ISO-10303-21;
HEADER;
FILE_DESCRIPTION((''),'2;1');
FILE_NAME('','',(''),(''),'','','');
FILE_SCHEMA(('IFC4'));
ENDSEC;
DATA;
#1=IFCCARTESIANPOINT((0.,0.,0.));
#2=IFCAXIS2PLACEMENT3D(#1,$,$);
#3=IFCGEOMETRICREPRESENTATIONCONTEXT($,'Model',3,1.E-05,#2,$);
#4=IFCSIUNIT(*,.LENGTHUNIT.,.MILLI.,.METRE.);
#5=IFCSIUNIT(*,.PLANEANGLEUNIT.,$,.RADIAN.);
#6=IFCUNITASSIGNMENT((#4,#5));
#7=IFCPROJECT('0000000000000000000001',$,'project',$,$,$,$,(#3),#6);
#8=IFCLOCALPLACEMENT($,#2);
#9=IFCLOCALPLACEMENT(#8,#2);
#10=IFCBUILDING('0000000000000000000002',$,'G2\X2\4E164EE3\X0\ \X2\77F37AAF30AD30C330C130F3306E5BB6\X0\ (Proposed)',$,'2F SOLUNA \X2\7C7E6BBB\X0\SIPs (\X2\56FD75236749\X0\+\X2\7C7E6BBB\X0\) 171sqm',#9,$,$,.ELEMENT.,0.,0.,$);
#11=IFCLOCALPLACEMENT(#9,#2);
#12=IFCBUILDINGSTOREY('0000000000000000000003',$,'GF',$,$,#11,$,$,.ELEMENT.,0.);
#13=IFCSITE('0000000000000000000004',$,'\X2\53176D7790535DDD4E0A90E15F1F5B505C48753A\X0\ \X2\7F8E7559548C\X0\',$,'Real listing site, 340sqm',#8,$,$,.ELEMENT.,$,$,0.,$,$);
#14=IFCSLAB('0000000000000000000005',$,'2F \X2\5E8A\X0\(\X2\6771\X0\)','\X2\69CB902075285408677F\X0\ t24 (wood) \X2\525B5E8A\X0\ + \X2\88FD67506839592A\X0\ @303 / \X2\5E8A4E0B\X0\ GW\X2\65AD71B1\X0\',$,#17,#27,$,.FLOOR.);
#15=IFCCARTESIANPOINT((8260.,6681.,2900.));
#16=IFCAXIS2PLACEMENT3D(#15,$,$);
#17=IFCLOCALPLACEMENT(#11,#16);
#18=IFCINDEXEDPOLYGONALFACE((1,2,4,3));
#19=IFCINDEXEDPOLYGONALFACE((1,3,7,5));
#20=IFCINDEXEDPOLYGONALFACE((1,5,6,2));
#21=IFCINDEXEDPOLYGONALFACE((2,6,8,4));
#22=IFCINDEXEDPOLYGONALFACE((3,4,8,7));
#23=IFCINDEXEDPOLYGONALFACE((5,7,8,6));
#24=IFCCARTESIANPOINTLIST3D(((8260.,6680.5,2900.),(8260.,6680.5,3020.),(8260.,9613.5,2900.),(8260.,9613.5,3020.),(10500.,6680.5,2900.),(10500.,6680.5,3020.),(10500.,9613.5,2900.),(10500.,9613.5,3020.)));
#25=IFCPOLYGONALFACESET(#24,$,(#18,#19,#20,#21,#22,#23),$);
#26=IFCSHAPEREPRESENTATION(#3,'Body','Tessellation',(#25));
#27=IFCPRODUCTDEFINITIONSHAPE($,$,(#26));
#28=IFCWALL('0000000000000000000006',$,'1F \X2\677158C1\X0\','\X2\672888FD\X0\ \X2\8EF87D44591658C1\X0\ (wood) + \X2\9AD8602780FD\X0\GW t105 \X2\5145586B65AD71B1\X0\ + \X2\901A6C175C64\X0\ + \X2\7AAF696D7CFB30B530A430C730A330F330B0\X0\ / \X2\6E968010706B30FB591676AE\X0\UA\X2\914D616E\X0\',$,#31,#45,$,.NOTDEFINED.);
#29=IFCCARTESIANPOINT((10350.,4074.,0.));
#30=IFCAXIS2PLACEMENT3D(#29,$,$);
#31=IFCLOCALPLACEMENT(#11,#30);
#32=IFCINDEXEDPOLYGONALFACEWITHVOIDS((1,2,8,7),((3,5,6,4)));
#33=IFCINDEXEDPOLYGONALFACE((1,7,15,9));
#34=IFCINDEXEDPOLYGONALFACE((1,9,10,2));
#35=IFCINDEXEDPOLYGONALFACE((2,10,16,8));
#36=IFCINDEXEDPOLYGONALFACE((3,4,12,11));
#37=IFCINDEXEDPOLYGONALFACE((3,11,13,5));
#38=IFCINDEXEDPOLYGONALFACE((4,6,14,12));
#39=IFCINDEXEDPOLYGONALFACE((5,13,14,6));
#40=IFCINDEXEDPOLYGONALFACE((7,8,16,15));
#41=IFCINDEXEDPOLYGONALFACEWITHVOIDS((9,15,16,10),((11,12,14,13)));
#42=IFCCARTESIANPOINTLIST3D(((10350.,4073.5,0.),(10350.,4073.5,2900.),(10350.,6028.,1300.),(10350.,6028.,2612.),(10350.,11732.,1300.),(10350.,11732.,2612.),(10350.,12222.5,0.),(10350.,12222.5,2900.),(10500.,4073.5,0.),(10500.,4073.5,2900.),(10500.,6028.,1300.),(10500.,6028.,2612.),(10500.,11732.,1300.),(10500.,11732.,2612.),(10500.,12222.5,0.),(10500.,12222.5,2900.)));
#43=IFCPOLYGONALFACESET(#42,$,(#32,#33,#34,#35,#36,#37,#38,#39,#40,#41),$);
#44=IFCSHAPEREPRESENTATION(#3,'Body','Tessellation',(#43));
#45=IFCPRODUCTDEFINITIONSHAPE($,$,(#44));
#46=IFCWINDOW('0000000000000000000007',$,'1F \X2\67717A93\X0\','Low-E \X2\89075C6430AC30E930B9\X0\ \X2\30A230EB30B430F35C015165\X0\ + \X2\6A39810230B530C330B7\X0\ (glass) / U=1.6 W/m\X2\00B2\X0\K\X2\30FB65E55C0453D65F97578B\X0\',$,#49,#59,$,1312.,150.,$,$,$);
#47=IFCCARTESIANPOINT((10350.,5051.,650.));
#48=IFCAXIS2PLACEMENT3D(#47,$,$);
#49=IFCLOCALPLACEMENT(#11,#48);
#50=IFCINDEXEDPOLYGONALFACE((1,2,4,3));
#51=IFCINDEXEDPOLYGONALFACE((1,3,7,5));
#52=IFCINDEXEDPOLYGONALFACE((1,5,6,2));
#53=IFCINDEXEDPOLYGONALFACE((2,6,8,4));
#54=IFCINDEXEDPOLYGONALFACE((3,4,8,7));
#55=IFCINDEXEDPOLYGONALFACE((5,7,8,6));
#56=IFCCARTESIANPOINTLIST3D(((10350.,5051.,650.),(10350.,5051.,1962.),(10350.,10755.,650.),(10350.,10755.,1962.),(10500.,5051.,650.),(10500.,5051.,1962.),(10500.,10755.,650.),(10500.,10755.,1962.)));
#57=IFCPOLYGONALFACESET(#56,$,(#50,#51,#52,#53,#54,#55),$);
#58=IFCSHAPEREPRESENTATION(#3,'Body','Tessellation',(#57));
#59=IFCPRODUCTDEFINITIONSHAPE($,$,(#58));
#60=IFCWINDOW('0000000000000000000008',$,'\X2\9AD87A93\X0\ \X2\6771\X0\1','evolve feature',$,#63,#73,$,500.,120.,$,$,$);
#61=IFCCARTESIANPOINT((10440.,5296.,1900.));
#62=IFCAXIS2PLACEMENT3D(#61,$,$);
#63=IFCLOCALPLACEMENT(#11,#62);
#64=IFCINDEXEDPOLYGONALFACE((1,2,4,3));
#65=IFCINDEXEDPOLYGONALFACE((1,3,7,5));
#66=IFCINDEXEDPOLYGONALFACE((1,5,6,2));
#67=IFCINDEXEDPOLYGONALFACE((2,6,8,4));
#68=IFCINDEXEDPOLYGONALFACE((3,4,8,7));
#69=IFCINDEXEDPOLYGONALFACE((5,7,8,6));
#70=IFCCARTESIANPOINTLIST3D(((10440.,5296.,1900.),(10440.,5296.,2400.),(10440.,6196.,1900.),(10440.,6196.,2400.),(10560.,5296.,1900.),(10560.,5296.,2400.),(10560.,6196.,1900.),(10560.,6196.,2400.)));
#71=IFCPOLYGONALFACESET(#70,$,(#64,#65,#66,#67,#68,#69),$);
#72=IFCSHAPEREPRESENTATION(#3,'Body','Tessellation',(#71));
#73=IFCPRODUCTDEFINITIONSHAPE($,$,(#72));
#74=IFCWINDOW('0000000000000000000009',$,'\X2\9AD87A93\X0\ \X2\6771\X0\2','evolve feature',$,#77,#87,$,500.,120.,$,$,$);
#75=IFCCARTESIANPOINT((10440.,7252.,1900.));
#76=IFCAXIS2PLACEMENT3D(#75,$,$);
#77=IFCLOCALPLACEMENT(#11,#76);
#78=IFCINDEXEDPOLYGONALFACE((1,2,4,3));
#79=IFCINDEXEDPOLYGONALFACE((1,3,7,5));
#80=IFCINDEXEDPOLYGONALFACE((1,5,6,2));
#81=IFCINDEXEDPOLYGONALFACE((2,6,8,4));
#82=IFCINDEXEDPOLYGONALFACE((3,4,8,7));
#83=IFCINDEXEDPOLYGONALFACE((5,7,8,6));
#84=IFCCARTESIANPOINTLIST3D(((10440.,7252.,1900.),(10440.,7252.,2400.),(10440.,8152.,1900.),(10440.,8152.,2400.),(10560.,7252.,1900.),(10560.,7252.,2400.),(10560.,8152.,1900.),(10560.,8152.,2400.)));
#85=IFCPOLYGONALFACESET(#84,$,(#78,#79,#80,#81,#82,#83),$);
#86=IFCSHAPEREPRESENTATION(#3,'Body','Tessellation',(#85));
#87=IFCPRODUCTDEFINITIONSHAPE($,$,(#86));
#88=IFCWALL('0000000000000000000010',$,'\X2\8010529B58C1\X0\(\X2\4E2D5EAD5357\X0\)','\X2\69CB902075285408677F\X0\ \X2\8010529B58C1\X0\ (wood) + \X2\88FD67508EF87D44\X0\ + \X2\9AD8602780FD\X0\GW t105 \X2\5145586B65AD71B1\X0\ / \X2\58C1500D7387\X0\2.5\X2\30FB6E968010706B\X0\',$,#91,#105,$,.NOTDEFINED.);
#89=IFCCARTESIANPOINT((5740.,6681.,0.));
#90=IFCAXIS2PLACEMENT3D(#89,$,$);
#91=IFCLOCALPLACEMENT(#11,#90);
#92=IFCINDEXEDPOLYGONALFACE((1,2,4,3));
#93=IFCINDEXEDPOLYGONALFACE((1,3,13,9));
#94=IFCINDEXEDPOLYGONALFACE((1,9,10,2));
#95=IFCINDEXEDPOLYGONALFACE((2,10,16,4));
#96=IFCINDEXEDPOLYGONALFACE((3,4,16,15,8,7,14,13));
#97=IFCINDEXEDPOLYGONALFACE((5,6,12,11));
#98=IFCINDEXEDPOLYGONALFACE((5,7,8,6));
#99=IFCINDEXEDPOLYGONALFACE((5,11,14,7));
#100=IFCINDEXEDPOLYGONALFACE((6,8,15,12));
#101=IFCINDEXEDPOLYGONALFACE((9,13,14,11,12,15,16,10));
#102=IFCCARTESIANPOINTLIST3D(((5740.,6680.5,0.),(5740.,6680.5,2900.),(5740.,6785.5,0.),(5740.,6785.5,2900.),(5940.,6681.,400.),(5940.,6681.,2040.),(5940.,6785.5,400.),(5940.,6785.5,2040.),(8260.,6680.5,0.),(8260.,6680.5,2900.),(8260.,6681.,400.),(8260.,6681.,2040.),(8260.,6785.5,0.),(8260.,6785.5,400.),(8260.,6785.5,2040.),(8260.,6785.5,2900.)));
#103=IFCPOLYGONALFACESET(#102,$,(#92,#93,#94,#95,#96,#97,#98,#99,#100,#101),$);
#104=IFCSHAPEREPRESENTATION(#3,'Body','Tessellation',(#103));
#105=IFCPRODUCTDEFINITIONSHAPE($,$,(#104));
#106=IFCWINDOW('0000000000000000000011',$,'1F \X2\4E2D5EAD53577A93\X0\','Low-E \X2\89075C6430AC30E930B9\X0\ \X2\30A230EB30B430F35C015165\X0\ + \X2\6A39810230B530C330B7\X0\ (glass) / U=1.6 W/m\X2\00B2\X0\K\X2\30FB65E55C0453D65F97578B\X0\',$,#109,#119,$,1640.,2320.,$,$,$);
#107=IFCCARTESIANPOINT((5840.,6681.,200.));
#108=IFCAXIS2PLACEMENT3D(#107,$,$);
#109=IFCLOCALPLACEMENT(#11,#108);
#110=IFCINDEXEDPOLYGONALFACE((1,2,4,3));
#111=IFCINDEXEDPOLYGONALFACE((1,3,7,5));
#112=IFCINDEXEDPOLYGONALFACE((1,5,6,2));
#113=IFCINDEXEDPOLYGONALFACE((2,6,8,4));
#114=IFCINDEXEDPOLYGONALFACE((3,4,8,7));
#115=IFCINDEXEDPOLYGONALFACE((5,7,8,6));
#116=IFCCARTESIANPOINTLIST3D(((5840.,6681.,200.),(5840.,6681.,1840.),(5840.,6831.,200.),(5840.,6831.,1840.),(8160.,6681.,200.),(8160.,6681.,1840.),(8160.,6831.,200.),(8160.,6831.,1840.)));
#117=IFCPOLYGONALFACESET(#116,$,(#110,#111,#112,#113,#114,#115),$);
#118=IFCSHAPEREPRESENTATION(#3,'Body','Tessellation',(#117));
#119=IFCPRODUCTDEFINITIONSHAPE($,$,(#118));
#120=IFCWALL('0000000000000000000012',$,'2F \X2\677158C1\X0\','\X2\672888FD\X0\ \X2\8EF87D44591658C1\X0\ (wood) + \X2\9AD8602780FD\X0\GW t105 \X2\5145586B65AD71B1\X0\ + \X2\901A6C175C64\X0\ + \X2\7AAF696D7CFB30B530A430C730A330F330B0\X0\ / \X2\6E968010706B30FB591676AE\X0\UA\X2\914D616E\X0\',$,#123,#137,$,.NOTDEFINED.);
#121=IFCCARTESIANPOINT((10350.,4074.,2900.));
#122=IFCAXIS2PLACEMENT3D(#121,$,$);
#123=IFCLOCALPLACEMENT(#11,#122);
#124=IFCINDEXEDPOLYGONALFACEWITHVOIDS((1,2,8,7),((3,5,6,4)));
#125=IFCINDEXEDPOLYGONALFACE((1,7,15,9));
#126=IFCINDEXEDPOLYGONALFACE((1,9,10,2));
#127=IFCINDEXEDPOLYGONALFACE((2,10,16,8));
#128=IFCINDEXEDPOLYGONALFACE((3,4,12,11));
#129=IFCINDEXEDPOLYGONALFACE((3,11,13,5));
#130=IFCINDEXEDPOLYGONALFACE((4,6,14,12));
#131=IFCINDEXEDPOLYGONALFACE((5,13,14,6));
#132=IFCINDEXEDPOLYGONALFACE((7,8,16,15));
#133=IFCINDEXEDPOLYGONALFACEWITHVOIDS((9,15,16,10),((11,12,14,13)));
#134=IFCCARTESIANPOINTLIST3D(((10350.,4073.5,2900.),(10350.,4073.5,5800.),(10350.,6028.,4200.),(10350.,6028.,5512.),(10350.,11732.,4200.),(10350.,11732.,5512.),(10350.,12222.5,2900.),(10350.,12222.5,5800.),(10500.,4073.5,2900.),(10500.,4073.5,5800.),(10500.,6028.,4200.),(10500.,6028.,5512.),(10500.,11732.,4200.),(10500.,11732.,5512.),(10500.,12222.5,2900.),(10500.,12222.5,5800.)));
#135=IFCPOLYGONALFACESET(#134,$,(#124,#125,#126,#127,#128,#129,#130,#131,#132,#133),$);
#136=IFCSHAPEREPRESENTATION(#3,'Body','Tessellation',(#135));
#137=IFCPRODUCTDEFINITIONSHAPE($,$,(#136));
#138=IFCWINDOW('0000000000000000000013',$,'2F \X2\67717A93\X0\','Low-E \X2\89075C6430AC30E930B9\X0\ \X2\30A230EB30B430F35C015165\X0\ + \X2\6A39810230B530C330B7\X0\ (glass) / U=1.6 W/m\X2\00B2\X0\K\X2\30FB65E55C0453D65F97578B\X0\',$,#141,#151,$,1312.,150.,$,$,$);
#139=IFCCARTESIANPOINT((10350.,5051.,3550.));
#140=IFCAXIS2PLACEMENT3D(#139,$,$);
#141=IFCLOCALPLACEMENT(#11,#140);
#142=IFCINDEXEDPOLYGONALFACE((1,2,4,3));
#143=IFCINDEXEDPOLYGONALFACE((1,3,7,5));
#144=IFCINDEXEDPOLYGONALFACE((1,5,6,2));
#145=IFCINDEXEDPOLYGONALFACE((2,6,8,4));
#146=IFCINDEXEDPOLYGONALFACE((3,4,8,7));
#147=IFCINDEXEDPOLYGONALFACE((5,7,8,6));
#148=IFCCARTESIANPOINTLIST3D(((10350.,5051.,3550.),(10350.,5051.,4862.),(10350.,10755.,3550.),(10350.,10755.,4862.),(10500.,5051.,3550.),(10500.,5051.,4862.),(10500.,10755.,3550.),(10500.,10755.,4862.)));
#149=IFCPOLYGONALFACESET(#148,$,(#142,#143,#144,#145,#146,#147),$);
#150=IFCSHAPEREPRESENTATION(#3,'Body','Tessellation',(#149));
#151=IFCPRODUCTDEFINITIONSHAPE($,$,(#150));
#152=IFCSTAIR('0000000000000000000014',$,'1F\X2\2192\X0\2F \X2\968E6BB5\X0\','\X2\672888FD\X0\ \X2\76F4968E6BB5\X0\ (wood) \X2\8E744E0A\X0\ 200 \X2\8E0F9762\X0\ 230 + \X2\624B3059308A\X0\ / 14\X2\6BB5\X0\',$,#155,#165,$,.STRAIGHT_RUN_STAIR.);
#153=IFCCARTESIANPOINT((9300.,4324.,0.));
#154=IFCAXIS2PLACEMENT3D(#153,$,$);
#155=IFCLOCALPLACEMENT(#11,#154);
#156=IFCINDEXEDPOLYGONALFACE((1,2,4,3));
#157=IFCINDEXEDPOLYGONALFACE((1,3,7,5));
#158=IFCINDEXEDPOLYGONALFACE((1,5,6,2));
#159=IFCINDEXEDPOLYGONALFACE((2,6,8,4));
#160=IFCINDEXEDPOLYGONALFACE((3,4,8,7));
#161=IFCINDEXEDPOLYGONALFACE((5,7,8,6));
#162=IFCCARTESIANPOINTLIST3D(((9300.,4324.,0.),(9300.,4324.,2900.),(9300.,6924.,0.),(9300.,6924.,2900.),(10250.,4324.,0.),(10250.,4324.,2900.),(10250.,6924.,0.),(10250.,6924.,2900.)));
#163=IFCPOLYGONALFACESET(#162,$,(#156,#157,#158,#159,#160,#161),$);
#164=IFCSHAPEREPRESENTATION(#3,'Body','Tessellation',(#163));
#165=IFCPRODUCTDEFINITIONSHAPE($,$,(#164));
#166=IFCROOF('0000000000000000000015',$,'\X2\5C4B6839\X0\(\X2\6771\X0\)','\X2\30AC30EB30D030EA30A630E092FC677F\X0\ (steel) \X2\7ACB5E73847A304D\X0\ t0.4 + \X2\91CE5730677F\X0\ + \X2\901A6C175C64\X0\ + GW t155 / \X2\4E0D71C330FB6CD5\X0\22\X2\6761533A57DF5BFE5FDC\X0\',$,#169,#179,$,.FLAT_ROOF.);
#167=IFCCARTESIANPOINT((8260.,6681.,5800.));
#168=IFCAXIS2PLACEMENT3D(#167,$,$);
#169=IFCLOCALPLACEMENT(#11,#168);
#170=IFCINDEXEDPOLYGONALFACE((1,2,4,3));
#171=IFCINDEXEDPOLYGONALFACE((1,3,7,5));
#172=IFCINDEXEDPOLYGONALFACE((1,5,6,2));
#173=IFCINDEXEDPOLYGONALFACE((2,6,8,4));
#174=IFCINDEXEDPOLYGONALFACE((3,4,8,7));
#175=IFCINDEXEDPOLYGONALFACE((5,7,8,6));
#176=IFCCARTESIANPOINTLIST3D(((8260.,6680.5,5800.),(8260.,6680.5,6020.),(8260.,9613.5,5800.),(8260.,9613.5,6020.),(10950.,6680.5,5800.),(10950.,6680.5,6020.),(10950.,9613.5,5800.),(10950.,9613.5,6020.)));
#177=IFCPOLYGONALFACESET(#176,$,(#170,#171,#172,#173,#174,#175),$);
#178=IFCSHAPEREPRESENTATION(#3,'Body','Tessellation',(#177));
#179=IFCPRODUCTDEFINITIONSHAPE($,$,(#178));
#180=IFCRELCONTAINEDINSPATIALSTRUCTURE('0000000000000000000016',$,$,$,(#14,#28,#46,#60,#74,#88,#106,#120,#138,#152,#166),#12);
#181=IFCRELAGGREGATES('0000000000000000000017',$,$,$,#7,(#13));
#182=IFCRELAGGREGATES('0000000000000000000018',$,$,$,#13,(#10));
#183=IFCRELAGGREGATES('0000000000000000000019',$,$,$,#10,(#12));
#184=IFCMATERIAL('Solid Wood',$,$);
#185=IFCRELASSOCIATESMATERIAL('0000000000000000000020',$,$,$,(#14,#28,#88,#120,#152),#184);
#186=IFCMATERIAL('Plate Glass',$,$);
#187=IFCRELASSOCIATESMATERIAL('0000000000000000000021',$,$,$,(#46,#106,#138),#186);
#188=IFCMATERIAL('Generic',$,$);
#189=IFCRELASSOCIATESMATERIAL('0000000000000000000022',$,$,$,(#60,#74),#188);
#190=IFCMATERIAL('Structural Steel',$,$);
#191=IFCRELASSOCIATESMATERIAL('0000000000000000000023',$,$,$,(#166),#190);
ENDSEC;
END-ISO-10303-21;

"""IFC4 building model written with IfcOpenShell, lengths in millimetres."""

from ifc_helpers import new_model, si_unit, frame, frame_2d, origin, place, context, project, spatial, rectangle, extrude, material, element, fill, save


model = new_model("IFC4")

# Units and contexts
model_context = context("Model", 3, precision=1e-05, world=origin())
ifc_project = project(units=[si_unit("LENGTHUNIT", "METRE", prefix="MILLI"), si_unit("PLANEANGLEUNIT", "RADIAN")], contexts=[model_context])

# Site, building, storey
site_placement = place(None, origin())
site = spatial("IfcSite", under=ifc_project, at=site_placement, Name="北海道川上郡弟子屈町 美留和", ObjectType="Real listing site, 340sqm", CompositionType="ELEMENT", RefElevation=0.0)
building_placement = place(site_placement, origin())
building = spatial("IfcBuilding", under=site, at=building_placement, Name="G2世代 石窯キッチンの家 (Proposed)", ObjectType="2F SOLUNA 籾殻SIPs (国産杉+籾殻) 171sqm", CompositionType="ELEMENT", ElevationOfRefHeight=0.0, ElevationOfTerrain=0.0)
storey_placement = place(building_placement, origin())
storey = spatial("IfcBuildingStorey", under=building, at=storey_placement, Name="GF", CompositionType="ELEMENT", Elevation=0.0)

# Slab
ifc_material_1 = material(Name="Solid Wood")
slab_1_placement = place(storey_placement, frame((8260.0, 6681.0, 2900.0)))
element("IfcSlab", 1, at=slab_1_placement, inside=storey, material=ifc_material_1, Name="2F 床(東)", Description="構造用合板 t24 (wood) 剛床 + 製材根太 @303 / 床下 GW断熱", PredefinedType="FLOOR", context=model_context, shape_type="SweptSolid", body=[
    extrude(rectangle(XDim=2240.0, YDim=2933.0, at=frame_2d((1120.0, 1466.0))), frame((8260.0, 6681.0, 2900.0)), (0.0, 0.0, 1.0), 120.0),
])

# Wall, openings, windows
wall_1_placement = place(storey_placement, frame((10350.0, 4074.0, 0.0)))
wall_1 = element("IfcWall", 2, at=wall_1_placement, inside=storey, material=ifc_material_1, Name="1F 東壁", Description="木製 軸組外壁 (wood) + 高性能GW t105 充填断熱 + 通気層 + 窯業系サイディング / 準耐火・外皮UA配慮", PredefinedType="NOTDEFINED", context=model_context, shape_type="SweptSolid", body=[
    extrude(rectangle(XDim=150.0, YDim=8149.0, at=frame_2d((75.0, 4074.0))), frame((10350.0, 4074.0, 0.0)), (0.0, 0.0, 1.0), 2900.0),
])
opening_1_placement = place(storey_placement, frame((10350.0, 5051.0, 650.0)))
opening_1 = element("IfcOpeningElement", 3, at=opening_1_placement, cuts=wall_1, PredefinedType="NOTDEFINED", context=model_context, shape_type="SweptSolid", body=[
    extrude(rectangle(XDim=150.0, YDim=5704.0, at=frame_2d((75.0, 2852.0))), frame((10350.0, 5051.0, 650.0)), (0.0, 0.0, 1.0), 1312.0),
])
opening_2_placement = place(storey_placement, frame((10440.0, 5296.0, 1900.0)))
opening_2 = element("IfcOpeningElement", 4, at=opening_2_placement, cuts=wall_1, PredefinedType="NOTDEFINED", context=model_context, shape_type="SweptSolid", body=[
    extrude(rectangle(XDim=120.0, YDim=900.0, at=frame_2d((60.0, 450.0))), frame((10440.0, 5296.0, 1900.0)), (0.0, 0.0, 1.0), 500.0),
])
opening_3_placement = place(storey_placement, frame((10440.0, 7252.0, 1900.0)))
opening_3 = element("IfcOpeningElement", 5, at=opening_3_placement, cuts=wall_1, PredefinedType="NOTDEFINED", context=model_context, shape_type="SweptSolid", body=[
    extrude(rectangle(XDim=120.0, YDim=900.0, at=frame_2d((60.0, 450.0))), frame((10440.0, 7252.0, 1900.0)), (0.0, 0.0, 1.0), 500.0),
])
ifc_material_2 = material(Name="Plate Glass")
window_1_placement = place(storey_placement, frame((10350.0, 5051.0, 650.0)))
window_1 = element("IfcWindow", 6, at=window_1_placement, inside=storey, material=ifc_material_2, Name="1F 東窓", Description="Low-E 複層ガラス アルゴン封入 + 樹脂サッシ (glass) / U=1.6 W/m²K・日射取得型", OverallHeight=1312.0, OverallWidth=150.0, context=model_context, shape_type="SweptSolid", body=[
    extrude(rectangle(XDim=150.0, YDim=5704.0, at=frame_2d((75.0, 2852.0))), frame((10350.0, 5051.0, 650.0)), (0.0, 0.0, 1.0), 1312.0),
])
fill(opening_1, window_1)
ifc_material_3 = material(Name="Generic")
window_2_placement = place(storey_placement, frame((10440.0, 5296.0, 1900.0)))
window_2 = element("IfcWindow", 7, at=window_2_placement, inside=storey, material=ifc_material_3, Name="高窓 東1", Description="evolve feature", OverallHeight=500.0, OverallWidth=120.0, context=model_context, shape_type="SweptSolid", body=[
    extrude(rectangle(XDim=120.0, YDim=900.0, at=frame_2d((60.0, 450.0))), frame((10440.0, 5296.0, 1900.0)), (0.0, 0.0, 1.0), 500.0),
])
fill(opening_2, window_2)
window_3_placement = place(storey_placement, frame((10440.0, 7252.0, 1900.0)))
window_3 = element("IfcWindow", 8, at=window_3_placement, inside=storey, material=ifc_material_3, Name="高窓 東2", Description="evolve feature", OverallHeight=500.0, OverallWidth=120.0, context=model_context, shape_type="SweptSolid", body=[
    extrude(rectangle(XDim=120.0, YDim=900.0, at=frame_2d((60.0, 450.0))), frame((10440.0, 7252.0, 1900.0)), (0.0, 0.0, 1.0), 500.0),
])
fill(opening_3, window_3)

# Wall, opening, window
wall_2_placement = place(storey_placement, frame((5740.0, 6681.0, 0.0)))
wall_2 = element("IfcWall", 9, at=wall_2_placement, inside=storey, material=ifc_material_1, Name="耐力壁(中庭南)", Description="構造用合板 耐力壁 (wood) + 製材軸組 + 高性能GW t105 充填断熱 / 壁倍率2.5・準耐火", PredefinedType="NOTDEFINED", context=model_context, shape_type="SweptSolid", body=[
    extrude(rectangle(XDim=2520.0, YDim=105.0, at=frame_2d((1260.0, 52.0))), frame((5740.0, 6681.0, 0.0)), (0.0, 0.0, 1.0), 2900.0),
])
opening_4_placement = place(storey_placement, frame((5840.0, 6681.0, 200.0)))
opening_4 = element("IfcOpeningElement", 10, at=opening_4_placement, cuts=wall_2, PredefinedType="NOTDEFINED", context=model_context, shape_type="SweptSolid", body=[
    extrude(rectangle(XDim=2320.0, YDim=150.0, at=frame_2d((1160.0, 75.0))), frame((5840.0, 6681.0, 200.0)), (0.0, 0.0, 1.0), 1640.0),
])
window_4_placement = place(storey_placement, frame((5840.0, 6681.0, 200.0)))
window_4 = element("IfcWindow", 11, at=window_4_placement, inside=storey, material=ifc_material_2, Name="1F 中庭南窓", Description="Low-E 複層ガラス アルゴン封入 + 樹脂サッシ (glass) / U=1.6 W/m²K・日射取得型", OverallHeight=1640.0, OverallWidth=2320.0, context=model_context, shape_type="SweptSolid", body=[
    extrude(rectangle(XDim=2320.0, YDim=150.0, at=frame_2d((1160.0, 75.0))), frame((5840.0, 6681.0, 200.0)), (0.0, 0.0, 1.0), 1640.0),
])
fill(opening_4, window_4)

# Wall, opening, window
wall_3_placement = place(storey_placement, frame((10350.0, 4074.0, 2900.0)))
wall_3 = element("IfcWall", 12, at=wall_3_placement, inside=storey, material=ifc_material_1, Name="2F 東壁", Description="木製 軸組外壁 (wood) + 高性能GW t105 充填断熱 + 通気層 + 窯業系サイディング / 準耐火・外皮UA配慮", PredefinedType="NOTDEFINED", context=model_context, shape_type="SweptSolid", body=[
    extrude(rectangle(XDim=150.0, YDim=8149.0, at=frame_2d((75.0, 4074.0))), frame((10350.0, 4074.0, 2900.0)), (0.0, 0.0, 1.0), 2900.0),
])
opening_5_placement = place(storey_placement, frame((10350.0, 5051.0, 3550.0)))
opening_5 = element("IfcOpeningElement", 13, at=opening_5_placement, cuts=wall_3, PredefinedType="NOTDEFINED", context=model_context, shape_type="SweptSolid", body=[
    extrude(rectangle(XDim=150.0, YDim=5704.0, at=frame_2d((75.0, 2852.0))), frame((10350.0, 5051.0, 3550.0)), (0.0, 0.0, 1.0), 1312.0),
])
window_5_placement = place(storey_placement, frame((10350.0, 5051.0, 3550.0)))
window_5 = element("IfcWindow", 14, at=window_5_placement, inside=storey, material=ifc_material_2, Name="2F 東窓", Description="Low-E 複層ガラス アルゴン封入 + 樹脂サッシ (glass) / U=1.6 W/m²K・日射取得型", OverallHeight=1312.0, OverallWidth=150.0, context=model_context, shape_type="SweptSolid", body=[
    extrude(rectangle(XDim=150.0, YDim=5704.0, at=frame_2d((75.0, 2852.0))), frame((10350.0, 5051.0, 3550.0)), (0.0, 0.0, 1.0), 1312.0),
])
fill(opening_5, window_5)

# Stair
stair_placement = place(storey_placement, frame((9300.0, 4324.0, 0.0)))
element("IfcStair", 15, at=stair_placement, inside=storey, material=ifc_material_1, Name="1F→2F 階段", Description="木製 直階段 (wood) 蹴上 200 踏面 230 + 手すり / 14段", PredefinedType="STRAIGHT_RUN_STAIR", context=model_context, shape_type="SweptSolid", body=[
    extrude(rectangle(XDim=950.0, YDim=2600.0, at=frame_2d((475.0, 1300.0))), frame((9300.0, 4324.0, 0.0)), (0.0, 0.0, 1.0), 2900.0),
])

# Roof
ifc_material_4 = material(Name="Structural Steel")
roof_placement = place(storey_placement, frame((8260.0, 6681.0, 5800.0)))
element("IfcRoof", 16, at=roof_placement, inside=storey, material=ifc_material_4, Name="屋根(東)", Description="ガルバリウム鋼板 (steel) 立平葺き t0.4 + 野地板 + 通気層 + GW t155 / 不燃・法22条区域対応", PredefinedType="FLAT_ROOF", context=model_context, shape_type="SweptSolid", body=[
    extrude(rectangle(XDim=2690.0, YDim=2933.0, at=frame_2d((1345.0, 1466.0))), frame((8260.0, 6681.0, 5800.0)), (0.0, 0.0, 1.0), 220.0),
])

save(model, "model.ifc")
